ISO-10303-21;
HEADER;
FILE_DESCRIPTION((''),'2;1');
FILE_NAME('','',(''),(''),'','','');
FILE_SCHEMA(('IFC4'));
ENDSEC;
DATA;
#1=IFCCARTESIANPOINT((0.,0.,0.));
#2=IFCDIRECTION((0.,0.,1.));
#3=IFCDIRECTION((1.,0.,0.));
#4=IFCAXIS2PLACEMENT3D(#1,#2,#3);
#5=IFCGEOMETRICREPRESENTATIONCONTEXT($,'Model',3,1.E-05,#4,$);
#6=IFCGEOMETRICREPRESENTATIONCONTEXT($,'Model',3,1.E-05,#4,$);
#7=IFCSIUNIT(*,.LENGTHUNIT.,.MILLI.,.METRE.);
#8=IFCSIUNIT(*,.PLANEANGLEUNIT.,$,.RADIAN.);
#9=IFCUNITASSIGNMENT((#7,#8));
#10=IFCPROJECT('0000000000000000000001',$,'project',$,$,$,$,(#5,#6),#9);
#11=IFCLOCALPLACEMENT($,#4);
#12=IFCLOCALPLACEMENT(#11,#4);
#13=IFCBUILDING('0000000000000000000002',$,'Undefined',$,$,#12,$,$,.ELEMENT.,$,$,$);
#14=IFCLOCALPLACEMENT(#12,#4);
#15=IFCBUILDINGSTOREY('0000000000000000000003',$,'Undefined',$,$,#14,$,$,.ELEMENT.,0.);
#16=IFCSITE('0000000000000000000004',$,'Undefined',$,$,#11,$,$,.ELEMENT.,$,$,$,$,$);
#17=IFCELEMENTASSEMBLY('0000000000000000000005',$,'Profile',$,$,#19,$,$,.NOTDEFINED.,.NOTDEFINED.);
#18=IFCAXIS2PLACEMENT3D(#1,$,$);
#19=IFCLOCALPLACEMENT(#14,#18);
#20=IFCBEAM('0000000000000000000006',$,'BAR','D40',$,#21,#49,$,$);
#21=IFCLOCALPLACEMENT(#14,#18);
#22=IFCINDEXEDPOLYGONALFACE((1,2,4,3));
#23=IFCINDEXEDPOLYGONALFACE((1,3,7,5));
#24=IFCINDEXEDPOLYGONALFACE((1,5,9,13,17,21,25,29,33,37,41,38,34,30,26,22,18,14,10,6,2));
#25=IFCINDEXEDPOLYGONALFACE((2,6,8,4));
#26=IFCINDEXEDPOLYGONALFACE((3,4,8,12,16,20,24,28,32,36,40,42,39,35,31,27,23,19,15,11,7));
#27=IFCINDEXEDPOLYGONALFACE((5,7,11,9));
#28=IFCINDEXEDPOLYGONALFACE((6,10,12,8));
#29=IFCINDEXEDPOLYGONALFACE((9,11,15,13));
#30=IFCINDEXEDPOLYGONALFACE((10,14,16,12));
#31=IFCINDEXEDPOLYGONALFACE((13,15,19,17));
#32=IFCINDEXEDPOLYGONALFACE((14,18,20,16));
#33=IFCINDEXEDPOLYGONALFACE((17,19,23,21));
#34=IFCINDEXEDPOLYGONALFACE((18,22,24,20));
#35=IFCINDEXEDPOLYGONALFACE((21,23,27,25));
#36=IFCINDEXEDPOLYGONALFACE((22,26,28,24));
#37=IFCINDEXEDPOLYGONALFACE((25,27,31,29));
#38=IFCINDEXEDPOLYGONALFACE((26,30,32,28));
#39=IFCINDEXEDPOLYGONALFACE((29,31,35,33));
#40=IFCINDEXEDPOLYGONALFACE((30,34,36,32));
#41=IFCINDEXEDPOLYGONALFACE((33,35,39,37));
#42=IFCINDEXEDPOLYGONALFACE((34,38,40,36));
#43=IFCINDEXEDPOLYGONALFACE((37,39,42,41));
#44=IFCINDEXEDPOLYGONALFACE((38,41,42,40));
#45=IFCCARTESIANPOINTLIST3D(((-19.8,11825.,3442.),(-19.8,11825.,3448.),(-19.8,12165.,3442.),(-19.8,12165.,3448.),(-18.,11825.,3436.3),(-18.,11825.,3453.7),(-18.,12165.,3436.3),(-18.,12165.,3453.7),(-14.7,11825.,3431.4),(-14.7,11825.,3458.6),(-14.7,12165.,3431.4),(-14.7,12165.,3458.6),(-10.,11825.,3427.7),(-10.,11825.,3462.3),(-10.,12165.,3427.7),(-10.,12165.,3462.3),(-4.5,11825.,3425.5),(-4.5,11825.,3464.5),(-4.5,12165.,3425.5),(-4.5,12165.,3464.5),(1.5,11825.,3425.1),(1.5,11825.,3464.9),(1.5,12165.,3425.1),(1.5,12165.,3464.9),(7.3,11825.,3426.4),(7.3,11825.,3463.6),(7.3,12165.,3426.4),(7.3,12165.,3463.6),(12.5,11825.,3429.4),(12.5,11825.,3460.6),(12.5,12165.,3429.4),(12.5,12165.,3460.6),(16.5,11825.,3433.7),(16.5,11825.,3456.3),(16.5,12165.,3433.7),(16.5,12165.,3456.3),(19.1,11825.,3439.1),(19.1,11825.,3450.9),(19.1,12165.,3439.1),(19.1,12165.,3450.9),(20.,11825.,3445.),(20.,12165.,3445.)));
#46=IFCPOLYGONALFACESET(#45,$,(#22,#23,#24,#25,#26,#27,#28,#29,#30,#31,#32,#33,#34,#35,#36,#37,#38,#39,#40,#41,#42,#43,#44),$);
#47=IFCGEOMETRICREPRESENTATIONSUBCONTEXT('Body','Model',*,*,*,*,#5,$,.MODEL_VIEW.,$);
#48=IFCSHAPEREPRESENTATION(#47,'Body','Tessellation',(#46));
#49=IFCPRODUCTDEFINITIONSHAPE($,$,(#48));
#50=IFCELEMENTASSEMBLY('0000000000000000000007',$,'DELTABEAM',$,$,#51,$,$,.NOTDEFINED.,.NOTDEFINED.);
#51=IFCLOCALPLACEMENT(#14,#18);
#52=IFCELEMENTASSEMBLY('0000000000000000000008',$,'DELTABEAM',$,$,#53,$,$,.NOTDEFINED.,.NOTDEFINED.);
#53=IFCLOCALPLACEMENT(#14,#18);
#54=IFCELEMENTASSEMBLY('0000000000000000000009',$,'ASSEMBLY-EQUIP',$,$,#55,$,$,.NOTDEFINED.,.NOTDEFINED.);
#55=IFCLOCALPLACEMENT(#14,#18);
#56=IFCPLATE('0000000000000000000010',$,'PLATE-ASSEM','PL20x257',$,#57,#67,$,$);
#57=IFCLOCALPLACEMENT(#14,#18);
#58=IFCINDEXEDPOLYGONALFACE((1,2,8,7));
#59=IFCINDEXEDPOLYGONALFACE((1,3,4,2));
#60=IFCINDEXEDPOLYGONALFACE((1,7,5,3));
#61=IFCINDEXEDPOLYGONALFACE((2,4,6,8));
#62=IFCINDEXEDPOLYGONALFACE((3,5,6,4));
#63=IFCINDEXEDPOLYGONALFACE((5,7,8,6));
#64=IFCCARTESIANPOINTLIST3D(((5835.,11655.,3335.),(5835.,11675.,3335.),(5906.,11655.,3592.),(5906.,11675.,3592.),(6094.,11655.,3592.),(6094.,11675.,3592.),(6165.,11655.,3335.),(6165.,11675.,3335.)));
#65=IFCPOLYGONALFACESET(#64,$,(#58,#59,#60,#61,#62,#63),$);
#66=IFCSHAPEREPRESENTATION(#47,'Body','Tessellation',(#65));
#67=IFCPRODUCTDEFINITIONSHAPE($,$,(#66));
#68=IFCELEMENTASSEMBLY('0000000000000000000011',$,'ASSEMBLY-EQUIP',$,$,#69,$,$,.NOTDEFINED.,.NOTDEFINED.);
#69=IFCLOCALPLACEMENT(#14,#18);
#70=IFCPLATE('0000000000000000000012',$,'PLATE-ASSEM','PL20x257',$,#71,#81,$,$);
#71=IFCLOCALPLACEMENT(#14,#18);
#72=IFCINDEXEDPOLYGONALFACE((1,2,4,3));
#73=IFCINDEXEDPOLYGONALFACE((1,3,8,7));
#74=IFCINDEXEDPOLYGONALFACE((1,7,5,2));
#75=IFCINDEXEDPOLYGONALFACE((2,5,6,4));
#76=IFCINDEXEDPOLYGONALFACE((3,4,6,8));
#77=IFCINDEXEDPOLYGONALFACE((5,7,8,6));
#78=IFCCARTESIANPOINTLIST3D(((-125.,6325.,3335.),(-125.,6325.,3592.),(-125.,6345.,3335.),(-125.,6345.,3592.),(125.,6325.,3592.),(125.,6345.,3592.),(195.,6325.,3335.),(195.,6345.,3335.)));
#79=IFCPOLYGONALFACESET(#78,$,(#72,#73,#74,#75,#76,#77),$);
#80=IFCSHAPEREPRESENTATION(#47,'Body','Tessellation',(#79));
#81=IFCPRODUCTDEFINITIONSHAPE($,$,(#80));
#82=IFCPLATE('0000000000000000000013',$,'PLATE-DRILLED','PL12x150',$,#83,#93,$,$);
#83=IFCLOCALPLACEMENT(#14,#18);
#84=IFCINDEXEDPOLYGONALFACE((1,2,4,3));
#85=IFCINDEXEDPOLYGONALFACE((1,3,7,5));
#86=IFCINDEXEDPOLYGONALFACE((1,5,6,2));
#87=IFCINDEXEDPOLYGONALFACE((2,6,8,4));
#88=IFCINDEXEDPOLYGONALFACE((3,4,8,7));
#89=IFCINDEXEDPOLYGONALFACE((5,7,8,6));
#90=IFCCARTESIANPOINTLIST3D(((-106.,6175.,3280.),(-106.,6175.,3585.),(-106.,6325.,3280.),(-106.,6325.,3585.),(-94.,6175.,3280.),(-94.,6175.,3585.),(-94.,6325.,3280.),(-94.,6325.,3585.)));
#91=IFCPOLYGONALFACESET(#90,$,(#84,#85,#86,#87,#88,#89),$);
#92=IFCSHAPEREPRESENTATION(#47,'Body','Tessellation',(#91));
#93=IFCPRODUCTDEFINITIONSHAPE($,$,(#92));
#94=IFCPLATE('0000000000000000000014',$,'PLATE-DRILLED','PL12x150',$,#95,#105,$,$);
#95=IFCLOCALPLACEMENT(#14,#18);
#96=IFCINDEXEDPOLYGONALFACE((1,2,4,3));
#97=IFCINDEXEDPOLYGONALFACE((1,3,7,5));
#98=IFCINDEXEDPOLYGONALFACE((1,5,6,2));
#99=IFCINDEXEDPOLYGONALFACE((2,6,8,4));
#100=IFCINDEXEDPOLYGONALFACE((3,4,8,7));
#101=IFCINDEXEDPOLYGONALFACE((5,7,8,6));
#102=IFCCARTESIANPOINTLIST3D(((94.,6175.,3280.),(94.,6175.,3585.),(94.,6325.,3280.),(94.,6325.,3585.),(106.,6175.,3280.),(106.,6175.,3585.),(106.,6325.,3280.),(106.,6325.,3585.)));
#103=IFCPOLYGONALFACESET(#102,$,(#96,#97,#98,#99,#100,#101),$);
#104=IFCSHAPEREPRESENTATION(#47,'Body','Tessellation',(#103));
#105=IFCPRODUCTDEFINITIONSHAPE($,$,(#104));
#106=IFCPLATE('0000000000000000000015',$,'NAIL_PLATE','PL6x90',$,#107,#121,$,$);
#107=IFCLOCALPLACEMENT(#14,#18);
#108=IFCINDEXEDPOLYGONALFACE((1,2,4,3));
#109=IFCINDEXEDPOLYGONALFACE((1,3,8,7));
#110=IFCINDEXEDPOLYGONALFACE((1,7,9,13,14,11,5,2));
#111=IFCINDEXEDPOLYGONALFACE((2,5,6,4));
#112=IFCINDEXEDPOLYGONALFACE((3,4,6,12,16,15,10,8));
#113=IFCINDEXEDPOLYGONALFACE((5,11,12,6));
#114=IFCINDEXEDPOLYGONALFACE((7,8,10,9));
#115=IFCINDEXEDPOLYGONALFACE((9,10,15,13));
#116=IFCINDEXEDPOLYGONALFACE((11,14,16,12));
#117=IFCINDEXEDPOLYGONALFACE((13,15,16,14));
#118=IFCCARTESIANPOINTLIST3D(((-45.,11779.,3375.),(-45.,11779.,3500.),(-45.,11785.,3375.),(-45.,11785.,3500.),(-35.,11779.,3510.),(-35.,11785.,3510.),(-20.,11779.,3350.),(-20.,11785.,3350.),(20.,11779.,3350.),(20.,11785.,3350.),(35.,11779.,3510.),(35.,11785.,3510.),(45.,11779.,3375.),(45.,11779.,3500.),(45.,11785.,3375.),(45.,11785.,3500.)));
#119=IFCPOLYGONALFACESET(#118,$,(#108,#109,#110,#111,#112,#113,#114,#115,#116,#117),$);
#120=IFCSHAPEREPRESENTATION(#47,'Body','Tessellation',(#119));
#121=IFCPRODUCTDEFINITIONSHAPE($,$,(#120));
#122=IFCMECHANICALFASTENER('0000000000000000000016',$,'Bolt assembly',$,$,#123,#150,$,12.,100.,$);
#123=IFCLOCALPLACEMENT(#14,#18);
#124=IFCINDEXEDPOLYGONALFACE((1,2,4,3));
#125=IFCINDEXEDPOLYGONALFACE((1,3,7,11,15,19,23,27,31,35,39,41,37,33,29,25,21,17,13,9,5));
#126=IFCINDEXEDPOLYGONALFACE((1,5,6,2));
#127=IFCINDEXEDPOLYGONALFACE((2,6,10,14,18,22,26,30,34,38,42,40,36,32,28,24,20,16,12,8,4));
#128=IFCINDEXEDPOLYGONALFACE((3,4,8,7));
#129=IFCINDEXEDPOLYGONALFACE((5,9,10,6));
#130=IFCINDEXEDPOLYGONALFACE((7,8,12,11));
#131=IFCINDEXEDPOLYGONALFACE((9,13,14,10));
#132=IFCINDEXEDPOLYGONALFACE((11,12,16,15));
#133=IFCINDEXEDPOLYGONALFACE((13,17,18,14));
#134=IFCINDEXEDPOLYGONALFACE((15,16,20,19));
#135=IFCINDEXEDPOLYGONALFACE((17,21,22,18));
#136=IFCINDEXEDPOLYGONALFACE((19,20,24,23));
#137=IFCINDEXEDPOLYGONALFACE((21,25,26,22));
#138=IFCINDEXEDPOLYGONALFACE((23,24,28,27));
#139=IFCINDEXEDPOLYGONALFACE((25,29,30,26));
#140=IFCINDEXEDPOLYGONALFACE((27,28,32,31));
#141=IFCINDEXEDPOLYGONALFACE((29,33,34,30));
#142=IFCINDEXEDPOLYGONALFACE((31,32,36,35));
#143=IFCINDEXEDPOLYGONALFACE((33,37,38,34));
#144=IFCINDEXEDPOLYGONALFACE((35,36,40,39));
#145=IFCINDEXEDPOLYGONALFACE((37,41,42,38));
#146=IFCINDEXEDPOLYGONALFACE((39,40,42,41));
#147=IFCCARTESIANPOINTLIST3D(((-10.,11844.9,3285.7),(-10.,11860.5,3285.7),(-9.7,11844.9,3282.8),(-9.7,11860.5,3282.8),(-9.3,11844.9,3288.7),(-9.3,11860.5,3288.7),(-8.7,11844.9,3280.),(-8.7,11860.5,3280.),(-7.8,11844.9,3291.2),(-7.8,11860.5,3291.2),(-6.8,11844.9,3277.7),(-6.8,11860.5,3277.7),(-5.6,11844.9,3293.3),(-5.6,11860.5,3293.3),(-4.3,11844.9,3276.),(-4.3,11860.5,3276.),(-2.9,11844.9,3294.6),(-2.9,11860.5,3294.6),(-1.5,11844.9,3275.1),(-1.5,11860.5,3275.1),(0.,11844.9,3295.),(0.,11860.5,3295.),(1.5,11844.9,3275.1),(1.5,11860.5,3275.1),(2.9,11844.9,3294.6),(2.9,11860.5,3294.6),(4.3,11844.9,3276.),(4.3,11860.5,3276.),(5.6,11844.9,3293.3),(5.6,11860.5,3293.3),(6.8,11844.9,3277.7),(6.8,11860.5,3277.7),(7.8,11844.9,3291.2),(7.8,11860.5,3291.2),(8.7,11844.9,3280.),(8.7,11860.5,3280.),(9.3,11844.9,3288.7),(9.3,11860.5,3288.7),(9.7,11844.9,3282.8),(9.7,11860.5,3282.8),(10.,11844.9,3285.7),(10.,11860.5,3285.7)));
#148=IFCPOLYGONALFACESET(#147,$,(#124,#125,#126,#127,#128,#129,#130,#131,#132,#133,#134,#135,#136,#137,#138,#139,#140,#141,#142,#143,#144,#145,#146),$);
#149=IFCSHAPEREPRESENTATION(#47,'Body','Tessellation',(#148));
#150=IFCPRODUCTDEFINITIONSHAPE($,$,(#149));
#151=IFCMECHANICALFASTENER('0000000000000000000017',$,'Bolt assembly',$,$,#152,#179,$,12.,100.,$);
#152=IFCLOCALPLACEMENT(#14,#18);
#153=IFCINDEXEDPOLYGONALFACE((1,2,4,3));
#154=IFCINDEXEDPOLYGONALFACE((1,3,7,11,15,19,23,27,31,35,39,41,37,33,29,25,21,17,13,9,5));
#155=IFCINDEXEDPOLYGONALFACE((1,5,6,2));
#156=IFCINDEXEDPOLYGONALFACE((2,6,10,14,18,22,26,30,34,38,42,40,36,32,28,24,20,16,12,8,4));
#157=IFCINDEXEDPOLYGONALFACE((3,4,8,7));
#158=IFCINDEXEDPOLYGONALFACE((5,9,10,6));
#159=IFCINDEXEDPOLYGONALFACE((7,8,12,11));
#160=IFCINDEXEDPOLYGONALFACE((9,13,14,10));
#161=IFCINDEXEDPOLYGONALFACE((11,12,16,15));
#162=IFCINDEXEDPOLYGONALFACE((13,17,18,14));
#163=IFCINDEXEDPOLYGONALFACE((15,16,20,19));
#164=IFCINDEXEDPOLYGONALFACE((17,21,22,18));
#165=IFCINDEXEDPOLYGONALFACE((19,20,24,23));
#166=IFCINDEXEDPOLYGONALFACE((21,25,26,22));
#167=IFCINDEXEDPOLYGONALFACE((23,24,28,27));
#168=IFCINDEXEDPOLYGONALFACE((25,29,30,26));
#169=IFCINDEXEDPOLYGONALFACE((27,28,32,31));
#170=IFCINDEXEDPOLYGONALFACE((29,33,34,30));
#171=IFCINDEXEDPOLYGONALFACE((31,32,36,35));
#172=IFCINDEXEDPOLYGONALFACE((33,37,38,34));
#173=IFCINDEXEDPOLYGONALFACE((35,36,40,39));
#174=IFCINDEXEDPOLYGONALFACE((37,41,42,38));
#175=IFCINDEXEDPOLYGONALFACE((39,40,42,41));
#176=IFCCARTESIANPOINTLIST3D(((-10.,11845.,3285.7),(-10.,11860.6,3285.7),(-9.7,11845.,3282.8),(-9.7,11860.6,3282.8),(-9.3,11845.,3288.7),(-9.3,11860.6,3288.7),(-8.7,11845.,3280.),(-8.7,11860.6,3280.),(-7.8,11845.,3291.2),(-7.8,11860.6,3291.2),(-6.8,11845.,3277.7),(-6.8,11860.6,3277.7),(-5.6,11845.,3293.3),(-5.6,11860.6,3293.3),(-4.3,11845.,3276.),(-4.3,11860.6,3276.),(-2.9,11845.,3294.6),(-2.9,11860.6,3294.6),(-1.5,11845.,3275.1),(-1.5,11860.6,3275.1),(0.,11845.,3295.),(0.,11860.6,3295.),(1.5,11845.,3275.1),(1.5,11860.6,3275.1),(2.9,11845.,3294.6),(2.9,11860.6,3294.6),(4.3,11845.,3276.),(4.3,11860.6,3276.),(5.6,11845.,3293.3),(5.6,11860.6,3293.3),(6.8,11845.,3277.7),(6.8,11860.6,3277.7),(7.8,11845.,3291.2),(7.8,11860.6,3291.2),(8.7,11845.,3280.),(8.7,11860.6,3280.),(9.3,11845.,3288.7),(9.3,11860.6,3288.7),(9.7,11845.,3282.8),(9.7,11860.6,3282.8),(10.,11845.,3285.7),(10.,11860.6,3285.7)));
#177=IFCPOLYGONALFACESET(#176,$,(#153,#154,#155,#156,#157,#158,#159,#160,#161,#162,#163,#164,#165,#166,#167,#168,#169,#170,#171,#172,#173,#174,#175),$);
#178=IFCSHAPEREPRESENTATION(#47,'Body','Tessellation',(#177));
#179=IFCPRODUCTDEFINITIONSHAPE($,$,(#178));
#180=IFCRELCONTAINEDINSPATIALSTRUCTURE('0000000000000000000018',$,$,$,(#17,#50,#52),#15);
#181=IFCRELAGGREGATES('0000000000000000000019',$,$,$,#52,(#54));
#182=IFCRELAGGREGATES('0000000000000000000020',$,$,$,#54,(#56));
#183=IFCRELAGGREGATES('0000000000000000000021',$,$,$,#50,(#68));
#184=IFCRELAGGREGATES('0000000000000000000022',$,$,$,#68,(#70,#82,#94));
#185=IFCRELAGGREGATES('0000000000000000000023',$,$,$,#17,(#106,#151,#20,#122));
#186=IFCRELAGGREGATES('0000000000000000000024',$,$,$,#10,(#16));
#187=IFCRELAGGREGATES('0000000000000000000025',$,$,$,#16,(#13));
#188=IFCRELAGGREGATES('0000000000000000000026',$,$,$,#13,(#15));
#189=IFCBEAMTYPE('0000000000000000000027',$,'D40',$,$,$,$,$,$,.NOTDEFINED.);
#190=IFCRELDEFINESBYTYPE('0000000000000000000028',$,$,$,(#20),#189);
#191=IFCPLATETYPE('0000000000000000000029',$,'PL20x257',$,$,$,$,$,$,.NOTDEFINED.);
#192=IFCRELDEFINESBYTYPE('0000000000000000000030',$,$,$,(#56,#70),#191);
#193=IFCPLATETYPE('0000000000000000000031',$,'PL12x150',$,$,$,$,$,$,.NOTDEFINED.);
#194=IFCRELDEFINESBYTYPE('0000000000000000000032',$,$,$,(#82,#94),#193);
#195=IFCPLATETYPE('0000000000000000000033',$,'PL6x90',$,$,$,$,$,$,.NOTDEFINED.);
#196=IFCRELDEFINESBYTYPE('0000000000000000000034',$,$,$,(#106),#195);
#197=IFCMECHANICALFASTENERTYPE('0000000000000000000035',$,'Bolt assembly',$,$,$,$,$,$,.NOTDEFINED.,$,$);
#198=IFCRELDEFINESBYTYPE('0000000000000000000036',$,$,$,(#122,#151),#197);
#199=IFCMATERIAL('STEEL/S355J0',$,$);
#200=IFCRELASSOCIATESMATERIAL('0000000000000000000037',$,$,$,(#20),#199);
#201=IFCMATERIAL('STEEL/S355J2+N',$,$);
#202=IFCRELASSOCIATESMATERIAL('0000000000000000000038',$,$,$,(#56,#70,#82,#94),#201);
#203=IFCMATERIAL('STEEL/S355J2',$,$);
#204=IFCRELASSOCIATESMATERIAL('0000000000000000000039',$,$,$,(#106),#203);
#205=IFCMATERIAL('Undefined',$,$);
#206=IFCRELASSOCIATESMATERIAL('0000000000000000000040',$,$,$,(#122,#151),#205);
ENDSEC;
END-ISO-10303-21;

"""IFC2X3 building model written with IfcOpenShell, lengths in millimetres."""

from ifc_helpers import new_model, si_unit, frame, origin_with_axes, origin_2d_with_axis, place, context, subcontext, project, spatial, polyline, circle, outline, extrude, source, transform, mapped, material, type_object, element, aggregate, save


model = new_model("IFC2X3")

# Units and contexts
model_context_1 = context("Model", 3, precision=1e-05, world=origin_with_axes())
model_context_2 = context("Model", 3, precision=1e-05, world=origin_with_axes())
body_context = subcontext(model_context_1, "Body", "Model", "MODEL_VIEW")
ifc_project = project(units=[si_unit("LENGTHUNIT", "METRE", prefix="MILLI"), si_unit("PLANEANGLEUNIT", "RADIAN")], contexts=[model_context_1, model_context_2])

# Site, building, storey
site_placement = place(None, origin_with_axes())
site = spatial("IfcSite", under=ifc_project, at=site_placement, Name="Undefined", CompositionType="ELEMENT")
building_placement = place(site_placement, origin_with_axes())
building = spatial("IfcBuilding", under=site, at=building_placement, Name="Undefined", CompositionType="ELEMENT")
storey_placement = place(building_placement, origin_with_axes())
storey = spatial("IfcBuildingStorey", under=building, at=storey_placement, Name="Undefined", CompositionType="ELEMENT", Elevation=0.0)

# Element assembly, beam
assembly_1_placement = place(storey_placement, origin_with_axes())
assembly_1 = element("IfcElementAssembly", 1, at=assembly_1_placement, inside=storey, Name="Profile", AssemblyPlace="NOTDEFINED", PredefinedType="NOTDEFINED")
ifc_material_1 = material(Name="STEEL/S355J0")
beam_type_1 = type_object("IfcBeamType", Name="D40", PredefinedType="NOTDEFINED")
beam_1_placement = place(assembly_1_placement, frame((0.0, 11825.0, 3445.0), z_axis=(0.0, 0.0, 1.0), x_axis=(0.0, 1.0, 0.0)))
beam_1 = element("IfcBeam", 2, at=beam_1_placement, type_object=beam_type_1, material=ifc_material_1, Name="BAR", Description="D40", context=body_context, shape_type="SweptSolid", body=[
    extrude(circle(Radius=20.0, at=origin_2d_with_axis()), frame((340.0, 0.0, 0.0), z_axis=(-1.0, 0.0, 0.0), x_axis=(0.0, -1.0, 0.0)), (0.0, 0.0, 1.0), 340.0),
])

# Element assembly
assembly_2_placement = place(storey_placement, origin_with_axes())
assembly_2 = element("IfcElementAssembly", 3, at=assembly_2_placement, inside=storey, Name="DELTABEAM", AssemblyPlace="NOTDEFINED", PredefinedType="NOTDEFINED")

# Element assemblies, plate
assembly_3_placement = place(storey_placement, origin_with_axes())
assembly_3 = element("IfcElementAssembly", 4, at=assembly_3_placement, inside=storey, Name="DELTABEAM", AssemblyPlace="NOTDEFINED", PredefinedType="NOTDEFINED")
assembly_4_placement = place(assembly_3_placement, origin_with_axes())
assembly_4 = element("IfcElementAssembly", 5, at=assembly_4_placement, Name="ASSEMBLY-EQUIP", AssemblyPlace="NOTDEFINED", PredefinedType="NOTDEFINED")
aggregate(assembly_3, [assembly_4])
ifc_material_2 = material(Name="STEEL/S355J2+N")
plate_type_1 = type_object("IfcPlateType", Name="PL20x257", PredefinedType="NOTDEFINED")
plate_1_placement = place(assembly_4_placement, frame((5835.0, 11665.0, 3335.0), z_axis=(0.0, -1.0, 0.0), x_axis=(1.0, 0.0, 0.0)))
plate_1 = element("IfcPlate", 6, at=plate_1_placement, type_object=plate_type_1, material=ifc_material_2, Name="PLATE-ASSEM", Description="PL20x257", context=body_context, shape_type="SweptSolid", body=[
    extrude(outline(polyline([(0.0, 0.0), (330.0, 0.0), (259.0, 257.0), (71.0, 257.0), (0.0, 0.0)])), frame((0.0, 0.0, -10.0), z_axis=(0.0, 0.0, 1.0), x_axis=(1.0, 0.0, 0.0)), (0.0, 0.0, 1.0), 20.0),
])
aggregate(assembly_4, [plate_1])

# Element assembly, plate
assembly_5_placement = place(assembly_2_placement, origin_with_axes())
assembly_5 = element("IfcElementAssembly", 7, at=assembly_5_placement, Name="ASSEMBLY-EQUIP", AssemblyPlace="NOTDEFINED", PredefinedType="NOTDEFINED")
plate_2_placement = place(assembly_5_placement, frame((195.0, 6335.0, 3335.0), z_axis=(0.0, 1.0, 0.0), x_axis=(-1.0, 0.0, 0.0)))
plate_2 = element("IfcPlate", 8, at=plate_2_placement, type_object=plate_type_1, material=ifc_material_2, Name="PLATE-ASSEM", Description="PL20x257", context=body_context, shape_type="SweptSolid", body=[
    extrude(outline(polyline([(0.0, 0.0), (320.0, 0.0), (320.0, 257.0), (70.0, 257.0), (0.0, 0.0)])), frame((0.0, 0.0, -10.0), z_axis=(0.0, 0.0, 1.0), x_axis=(1.0, 0.0, 0.0)), (0.0, 0.0, 1.0), 20.0),
])

# Plates
ifc_material_3 = material(Name="STEEL/S355J2")
aggregate(assembly_2, [assembly_5])
plate_type_2 = type_object("IfcPlateType", Name="PL12x150", PredefinedType="NOTDEFINED")
plate_3_placement = place(assembly_5_placement, frame((-100.0, 6325.0, 3585.0), z_axis=(1.0, 0.0, 0.0), x_axis=(0.0, -1.0, 0.0)))
plate_3 = element("IfcPlate", 9, at=plate_3_placement, type_object=plate_type_2, material=ifc_material_2, Name="PLATE-DRILLED", Description="PL12x150", context=body_context, shape_type="SweptSolid", body=[
    extrude(outline(polyline([(0.0, 0.0), (150.0, 0.0), (150.0, 0.0), (150.0, 305.0), (150.0, 305.0), (0.0, 305.0), (0.0, 305.0), (0.0, 0.0)])), frame((0.0, 0.0, -6.0), z_axis=(0.0, 0.0, 1.0), x_axis=(1.0, 0.0, 0.0)), (0.0, 0.0, 1.0), 12.0),
])
plate_4_placement = place(assembly_5_placement, frame((100.0, 6325.0, 3585.0), z_axis=(1.0, 0.0, 0.0), x_axis=(0.0, -1.0, 0.0)))
plate_4 = element("IfcPlate", 10, at=plate_4_placement, type_object=plate_type_2, material=ifc_material_2, Name="PLATE-DRILLED", Description="PL12x150", context=body_context, shape_type="SweptSolid", body=[
    extrude(outline(polyline([(0.0, 0.0), (150.0, 0.0), (150.0, 0.0), (150.0, 305.0), (150.0, 305.0), (0.0, 305.0), (0.0, 305.0), (0.0, 0.0)])), frame((0.0, 0.0, -6.0), z_axis=(0.0, 0.0, 1.0), x_axis=(1.0, 0.0, 0.0)), (0.0, 0.0, 1.0), 12.0),
])
plate_type_3 = type_object("IfcPlateType", Name="PL6x90", PredefinedType="NOTDEFINED")
plate_5_placement = place(assembly_1_placement, frame((-45.0, 11782.0, 3510.0), z_axis=(0.0, 1.0, 0.0), x_axis=(1.0, 0.0, 0.0)))
plate_5 = element("IfcPlate", 11, at=plate_5_placement, type_object=plate_type_3, material=ifc_material_3, Name="NAIL_PLATE", Description="PL6x90", context=body_context, shape_type="SweptSolid", body=[
    extrude(outline(polyline([(0.0, 10.0), (10.0, 0.0), (80.0, 0.0), (90.0, 10.0), (90.0, 135.0), (65.0, 160.0), (25.0, 160.0), (0.0, 135.0), (0.0, 10.0)])), frame((0.0, 0.0, -3.0), z_axis=(0.0, 0.0, 1.0), x_axis=(1.0, 0.0, 0.0)), (0.0, 0.0, 1.0), 6.0),
])

# Mechanical fasteners
mechanical_fastener_type = type_object("IfcMechanicalFastenerType", Name="Bolt assembly")
aggregate(assembly_5, [plate_2, plate_3, plate_4])
ifc_material_4 = material(Name="Undefined")
shared_shape_1 = source(origin_with_axes(), body_context, "Body", "SweptSolid", [
    extrude(circle(Radius=10.0, at=origin_2d_with_axis()), frame((0.0, -15.5, 0.0), z_axis=(0.0, 1.0, 0.0), x_axis=(1.0, 0.0, 0.0)), (0.0, 0.0, 1.0), 15.6),
])
mechanical_fastener_1_placement = place(assembly_1_placement, frame((0.0, 11845.0, 3285.0), z_axis=(1.0, 0.0, 0.0), x_axis=(0.0, 0.0, 1.0)))
mechanical_fastener_1 = element("IfcMechanicalFastener", 12, at=mechanical_fastener_1_placement, type_object=mechanical_fastener_type, material=ifc_material_4, Name="Bolt assembly", NominalDiameter=12.0, NominalLength=100.0, context=body_context, shape_type="MappedRepresentation", body=[
    mapped(shared_shape_1, transform((0.0, 0.0, 0.0))),
])
shared_shape_2 = source(origin_with_axes(), body_context, "Body", "SweptSolid", [
    extrude(circle(Radius=10.0, at=origin_2d_with_axis()), frame((0.0, 0.0, 0.0), z_axis=(0.0, 1.0, 0.0), x_axis=(1.0, 0.0, 0.0)), (0.0, 0.0, 1.0), 15.6),
])
mechanical_fastener_2_placement = place(assembly_1_placement, frame((0.0, 11845.0, 3285.0), z_axis=(-1.0, 0.0, 0.0), x_axis=(0.0, 0.0, 1.0)))
mechanical_fastener_2 = element("IfcMechanicalFastener", 13, at=mechanical_fastener_2_placement, type_object=mechanical_fastener_type, material=ifc_material_4, Name="Bolt assembly", NominalDiameter=12.0, NominalLength=100.0, context=body_context, shape_type="MappedRepresentation", body=[
    mapped(shared_shape_2, transform((0.0, 0.0, 0.0))),
])
aggregate(assembly_1, [plate_5, mechanical_fastener_2, beam_1, mechanical_fastener_1])

save(model, "model.ifc")
